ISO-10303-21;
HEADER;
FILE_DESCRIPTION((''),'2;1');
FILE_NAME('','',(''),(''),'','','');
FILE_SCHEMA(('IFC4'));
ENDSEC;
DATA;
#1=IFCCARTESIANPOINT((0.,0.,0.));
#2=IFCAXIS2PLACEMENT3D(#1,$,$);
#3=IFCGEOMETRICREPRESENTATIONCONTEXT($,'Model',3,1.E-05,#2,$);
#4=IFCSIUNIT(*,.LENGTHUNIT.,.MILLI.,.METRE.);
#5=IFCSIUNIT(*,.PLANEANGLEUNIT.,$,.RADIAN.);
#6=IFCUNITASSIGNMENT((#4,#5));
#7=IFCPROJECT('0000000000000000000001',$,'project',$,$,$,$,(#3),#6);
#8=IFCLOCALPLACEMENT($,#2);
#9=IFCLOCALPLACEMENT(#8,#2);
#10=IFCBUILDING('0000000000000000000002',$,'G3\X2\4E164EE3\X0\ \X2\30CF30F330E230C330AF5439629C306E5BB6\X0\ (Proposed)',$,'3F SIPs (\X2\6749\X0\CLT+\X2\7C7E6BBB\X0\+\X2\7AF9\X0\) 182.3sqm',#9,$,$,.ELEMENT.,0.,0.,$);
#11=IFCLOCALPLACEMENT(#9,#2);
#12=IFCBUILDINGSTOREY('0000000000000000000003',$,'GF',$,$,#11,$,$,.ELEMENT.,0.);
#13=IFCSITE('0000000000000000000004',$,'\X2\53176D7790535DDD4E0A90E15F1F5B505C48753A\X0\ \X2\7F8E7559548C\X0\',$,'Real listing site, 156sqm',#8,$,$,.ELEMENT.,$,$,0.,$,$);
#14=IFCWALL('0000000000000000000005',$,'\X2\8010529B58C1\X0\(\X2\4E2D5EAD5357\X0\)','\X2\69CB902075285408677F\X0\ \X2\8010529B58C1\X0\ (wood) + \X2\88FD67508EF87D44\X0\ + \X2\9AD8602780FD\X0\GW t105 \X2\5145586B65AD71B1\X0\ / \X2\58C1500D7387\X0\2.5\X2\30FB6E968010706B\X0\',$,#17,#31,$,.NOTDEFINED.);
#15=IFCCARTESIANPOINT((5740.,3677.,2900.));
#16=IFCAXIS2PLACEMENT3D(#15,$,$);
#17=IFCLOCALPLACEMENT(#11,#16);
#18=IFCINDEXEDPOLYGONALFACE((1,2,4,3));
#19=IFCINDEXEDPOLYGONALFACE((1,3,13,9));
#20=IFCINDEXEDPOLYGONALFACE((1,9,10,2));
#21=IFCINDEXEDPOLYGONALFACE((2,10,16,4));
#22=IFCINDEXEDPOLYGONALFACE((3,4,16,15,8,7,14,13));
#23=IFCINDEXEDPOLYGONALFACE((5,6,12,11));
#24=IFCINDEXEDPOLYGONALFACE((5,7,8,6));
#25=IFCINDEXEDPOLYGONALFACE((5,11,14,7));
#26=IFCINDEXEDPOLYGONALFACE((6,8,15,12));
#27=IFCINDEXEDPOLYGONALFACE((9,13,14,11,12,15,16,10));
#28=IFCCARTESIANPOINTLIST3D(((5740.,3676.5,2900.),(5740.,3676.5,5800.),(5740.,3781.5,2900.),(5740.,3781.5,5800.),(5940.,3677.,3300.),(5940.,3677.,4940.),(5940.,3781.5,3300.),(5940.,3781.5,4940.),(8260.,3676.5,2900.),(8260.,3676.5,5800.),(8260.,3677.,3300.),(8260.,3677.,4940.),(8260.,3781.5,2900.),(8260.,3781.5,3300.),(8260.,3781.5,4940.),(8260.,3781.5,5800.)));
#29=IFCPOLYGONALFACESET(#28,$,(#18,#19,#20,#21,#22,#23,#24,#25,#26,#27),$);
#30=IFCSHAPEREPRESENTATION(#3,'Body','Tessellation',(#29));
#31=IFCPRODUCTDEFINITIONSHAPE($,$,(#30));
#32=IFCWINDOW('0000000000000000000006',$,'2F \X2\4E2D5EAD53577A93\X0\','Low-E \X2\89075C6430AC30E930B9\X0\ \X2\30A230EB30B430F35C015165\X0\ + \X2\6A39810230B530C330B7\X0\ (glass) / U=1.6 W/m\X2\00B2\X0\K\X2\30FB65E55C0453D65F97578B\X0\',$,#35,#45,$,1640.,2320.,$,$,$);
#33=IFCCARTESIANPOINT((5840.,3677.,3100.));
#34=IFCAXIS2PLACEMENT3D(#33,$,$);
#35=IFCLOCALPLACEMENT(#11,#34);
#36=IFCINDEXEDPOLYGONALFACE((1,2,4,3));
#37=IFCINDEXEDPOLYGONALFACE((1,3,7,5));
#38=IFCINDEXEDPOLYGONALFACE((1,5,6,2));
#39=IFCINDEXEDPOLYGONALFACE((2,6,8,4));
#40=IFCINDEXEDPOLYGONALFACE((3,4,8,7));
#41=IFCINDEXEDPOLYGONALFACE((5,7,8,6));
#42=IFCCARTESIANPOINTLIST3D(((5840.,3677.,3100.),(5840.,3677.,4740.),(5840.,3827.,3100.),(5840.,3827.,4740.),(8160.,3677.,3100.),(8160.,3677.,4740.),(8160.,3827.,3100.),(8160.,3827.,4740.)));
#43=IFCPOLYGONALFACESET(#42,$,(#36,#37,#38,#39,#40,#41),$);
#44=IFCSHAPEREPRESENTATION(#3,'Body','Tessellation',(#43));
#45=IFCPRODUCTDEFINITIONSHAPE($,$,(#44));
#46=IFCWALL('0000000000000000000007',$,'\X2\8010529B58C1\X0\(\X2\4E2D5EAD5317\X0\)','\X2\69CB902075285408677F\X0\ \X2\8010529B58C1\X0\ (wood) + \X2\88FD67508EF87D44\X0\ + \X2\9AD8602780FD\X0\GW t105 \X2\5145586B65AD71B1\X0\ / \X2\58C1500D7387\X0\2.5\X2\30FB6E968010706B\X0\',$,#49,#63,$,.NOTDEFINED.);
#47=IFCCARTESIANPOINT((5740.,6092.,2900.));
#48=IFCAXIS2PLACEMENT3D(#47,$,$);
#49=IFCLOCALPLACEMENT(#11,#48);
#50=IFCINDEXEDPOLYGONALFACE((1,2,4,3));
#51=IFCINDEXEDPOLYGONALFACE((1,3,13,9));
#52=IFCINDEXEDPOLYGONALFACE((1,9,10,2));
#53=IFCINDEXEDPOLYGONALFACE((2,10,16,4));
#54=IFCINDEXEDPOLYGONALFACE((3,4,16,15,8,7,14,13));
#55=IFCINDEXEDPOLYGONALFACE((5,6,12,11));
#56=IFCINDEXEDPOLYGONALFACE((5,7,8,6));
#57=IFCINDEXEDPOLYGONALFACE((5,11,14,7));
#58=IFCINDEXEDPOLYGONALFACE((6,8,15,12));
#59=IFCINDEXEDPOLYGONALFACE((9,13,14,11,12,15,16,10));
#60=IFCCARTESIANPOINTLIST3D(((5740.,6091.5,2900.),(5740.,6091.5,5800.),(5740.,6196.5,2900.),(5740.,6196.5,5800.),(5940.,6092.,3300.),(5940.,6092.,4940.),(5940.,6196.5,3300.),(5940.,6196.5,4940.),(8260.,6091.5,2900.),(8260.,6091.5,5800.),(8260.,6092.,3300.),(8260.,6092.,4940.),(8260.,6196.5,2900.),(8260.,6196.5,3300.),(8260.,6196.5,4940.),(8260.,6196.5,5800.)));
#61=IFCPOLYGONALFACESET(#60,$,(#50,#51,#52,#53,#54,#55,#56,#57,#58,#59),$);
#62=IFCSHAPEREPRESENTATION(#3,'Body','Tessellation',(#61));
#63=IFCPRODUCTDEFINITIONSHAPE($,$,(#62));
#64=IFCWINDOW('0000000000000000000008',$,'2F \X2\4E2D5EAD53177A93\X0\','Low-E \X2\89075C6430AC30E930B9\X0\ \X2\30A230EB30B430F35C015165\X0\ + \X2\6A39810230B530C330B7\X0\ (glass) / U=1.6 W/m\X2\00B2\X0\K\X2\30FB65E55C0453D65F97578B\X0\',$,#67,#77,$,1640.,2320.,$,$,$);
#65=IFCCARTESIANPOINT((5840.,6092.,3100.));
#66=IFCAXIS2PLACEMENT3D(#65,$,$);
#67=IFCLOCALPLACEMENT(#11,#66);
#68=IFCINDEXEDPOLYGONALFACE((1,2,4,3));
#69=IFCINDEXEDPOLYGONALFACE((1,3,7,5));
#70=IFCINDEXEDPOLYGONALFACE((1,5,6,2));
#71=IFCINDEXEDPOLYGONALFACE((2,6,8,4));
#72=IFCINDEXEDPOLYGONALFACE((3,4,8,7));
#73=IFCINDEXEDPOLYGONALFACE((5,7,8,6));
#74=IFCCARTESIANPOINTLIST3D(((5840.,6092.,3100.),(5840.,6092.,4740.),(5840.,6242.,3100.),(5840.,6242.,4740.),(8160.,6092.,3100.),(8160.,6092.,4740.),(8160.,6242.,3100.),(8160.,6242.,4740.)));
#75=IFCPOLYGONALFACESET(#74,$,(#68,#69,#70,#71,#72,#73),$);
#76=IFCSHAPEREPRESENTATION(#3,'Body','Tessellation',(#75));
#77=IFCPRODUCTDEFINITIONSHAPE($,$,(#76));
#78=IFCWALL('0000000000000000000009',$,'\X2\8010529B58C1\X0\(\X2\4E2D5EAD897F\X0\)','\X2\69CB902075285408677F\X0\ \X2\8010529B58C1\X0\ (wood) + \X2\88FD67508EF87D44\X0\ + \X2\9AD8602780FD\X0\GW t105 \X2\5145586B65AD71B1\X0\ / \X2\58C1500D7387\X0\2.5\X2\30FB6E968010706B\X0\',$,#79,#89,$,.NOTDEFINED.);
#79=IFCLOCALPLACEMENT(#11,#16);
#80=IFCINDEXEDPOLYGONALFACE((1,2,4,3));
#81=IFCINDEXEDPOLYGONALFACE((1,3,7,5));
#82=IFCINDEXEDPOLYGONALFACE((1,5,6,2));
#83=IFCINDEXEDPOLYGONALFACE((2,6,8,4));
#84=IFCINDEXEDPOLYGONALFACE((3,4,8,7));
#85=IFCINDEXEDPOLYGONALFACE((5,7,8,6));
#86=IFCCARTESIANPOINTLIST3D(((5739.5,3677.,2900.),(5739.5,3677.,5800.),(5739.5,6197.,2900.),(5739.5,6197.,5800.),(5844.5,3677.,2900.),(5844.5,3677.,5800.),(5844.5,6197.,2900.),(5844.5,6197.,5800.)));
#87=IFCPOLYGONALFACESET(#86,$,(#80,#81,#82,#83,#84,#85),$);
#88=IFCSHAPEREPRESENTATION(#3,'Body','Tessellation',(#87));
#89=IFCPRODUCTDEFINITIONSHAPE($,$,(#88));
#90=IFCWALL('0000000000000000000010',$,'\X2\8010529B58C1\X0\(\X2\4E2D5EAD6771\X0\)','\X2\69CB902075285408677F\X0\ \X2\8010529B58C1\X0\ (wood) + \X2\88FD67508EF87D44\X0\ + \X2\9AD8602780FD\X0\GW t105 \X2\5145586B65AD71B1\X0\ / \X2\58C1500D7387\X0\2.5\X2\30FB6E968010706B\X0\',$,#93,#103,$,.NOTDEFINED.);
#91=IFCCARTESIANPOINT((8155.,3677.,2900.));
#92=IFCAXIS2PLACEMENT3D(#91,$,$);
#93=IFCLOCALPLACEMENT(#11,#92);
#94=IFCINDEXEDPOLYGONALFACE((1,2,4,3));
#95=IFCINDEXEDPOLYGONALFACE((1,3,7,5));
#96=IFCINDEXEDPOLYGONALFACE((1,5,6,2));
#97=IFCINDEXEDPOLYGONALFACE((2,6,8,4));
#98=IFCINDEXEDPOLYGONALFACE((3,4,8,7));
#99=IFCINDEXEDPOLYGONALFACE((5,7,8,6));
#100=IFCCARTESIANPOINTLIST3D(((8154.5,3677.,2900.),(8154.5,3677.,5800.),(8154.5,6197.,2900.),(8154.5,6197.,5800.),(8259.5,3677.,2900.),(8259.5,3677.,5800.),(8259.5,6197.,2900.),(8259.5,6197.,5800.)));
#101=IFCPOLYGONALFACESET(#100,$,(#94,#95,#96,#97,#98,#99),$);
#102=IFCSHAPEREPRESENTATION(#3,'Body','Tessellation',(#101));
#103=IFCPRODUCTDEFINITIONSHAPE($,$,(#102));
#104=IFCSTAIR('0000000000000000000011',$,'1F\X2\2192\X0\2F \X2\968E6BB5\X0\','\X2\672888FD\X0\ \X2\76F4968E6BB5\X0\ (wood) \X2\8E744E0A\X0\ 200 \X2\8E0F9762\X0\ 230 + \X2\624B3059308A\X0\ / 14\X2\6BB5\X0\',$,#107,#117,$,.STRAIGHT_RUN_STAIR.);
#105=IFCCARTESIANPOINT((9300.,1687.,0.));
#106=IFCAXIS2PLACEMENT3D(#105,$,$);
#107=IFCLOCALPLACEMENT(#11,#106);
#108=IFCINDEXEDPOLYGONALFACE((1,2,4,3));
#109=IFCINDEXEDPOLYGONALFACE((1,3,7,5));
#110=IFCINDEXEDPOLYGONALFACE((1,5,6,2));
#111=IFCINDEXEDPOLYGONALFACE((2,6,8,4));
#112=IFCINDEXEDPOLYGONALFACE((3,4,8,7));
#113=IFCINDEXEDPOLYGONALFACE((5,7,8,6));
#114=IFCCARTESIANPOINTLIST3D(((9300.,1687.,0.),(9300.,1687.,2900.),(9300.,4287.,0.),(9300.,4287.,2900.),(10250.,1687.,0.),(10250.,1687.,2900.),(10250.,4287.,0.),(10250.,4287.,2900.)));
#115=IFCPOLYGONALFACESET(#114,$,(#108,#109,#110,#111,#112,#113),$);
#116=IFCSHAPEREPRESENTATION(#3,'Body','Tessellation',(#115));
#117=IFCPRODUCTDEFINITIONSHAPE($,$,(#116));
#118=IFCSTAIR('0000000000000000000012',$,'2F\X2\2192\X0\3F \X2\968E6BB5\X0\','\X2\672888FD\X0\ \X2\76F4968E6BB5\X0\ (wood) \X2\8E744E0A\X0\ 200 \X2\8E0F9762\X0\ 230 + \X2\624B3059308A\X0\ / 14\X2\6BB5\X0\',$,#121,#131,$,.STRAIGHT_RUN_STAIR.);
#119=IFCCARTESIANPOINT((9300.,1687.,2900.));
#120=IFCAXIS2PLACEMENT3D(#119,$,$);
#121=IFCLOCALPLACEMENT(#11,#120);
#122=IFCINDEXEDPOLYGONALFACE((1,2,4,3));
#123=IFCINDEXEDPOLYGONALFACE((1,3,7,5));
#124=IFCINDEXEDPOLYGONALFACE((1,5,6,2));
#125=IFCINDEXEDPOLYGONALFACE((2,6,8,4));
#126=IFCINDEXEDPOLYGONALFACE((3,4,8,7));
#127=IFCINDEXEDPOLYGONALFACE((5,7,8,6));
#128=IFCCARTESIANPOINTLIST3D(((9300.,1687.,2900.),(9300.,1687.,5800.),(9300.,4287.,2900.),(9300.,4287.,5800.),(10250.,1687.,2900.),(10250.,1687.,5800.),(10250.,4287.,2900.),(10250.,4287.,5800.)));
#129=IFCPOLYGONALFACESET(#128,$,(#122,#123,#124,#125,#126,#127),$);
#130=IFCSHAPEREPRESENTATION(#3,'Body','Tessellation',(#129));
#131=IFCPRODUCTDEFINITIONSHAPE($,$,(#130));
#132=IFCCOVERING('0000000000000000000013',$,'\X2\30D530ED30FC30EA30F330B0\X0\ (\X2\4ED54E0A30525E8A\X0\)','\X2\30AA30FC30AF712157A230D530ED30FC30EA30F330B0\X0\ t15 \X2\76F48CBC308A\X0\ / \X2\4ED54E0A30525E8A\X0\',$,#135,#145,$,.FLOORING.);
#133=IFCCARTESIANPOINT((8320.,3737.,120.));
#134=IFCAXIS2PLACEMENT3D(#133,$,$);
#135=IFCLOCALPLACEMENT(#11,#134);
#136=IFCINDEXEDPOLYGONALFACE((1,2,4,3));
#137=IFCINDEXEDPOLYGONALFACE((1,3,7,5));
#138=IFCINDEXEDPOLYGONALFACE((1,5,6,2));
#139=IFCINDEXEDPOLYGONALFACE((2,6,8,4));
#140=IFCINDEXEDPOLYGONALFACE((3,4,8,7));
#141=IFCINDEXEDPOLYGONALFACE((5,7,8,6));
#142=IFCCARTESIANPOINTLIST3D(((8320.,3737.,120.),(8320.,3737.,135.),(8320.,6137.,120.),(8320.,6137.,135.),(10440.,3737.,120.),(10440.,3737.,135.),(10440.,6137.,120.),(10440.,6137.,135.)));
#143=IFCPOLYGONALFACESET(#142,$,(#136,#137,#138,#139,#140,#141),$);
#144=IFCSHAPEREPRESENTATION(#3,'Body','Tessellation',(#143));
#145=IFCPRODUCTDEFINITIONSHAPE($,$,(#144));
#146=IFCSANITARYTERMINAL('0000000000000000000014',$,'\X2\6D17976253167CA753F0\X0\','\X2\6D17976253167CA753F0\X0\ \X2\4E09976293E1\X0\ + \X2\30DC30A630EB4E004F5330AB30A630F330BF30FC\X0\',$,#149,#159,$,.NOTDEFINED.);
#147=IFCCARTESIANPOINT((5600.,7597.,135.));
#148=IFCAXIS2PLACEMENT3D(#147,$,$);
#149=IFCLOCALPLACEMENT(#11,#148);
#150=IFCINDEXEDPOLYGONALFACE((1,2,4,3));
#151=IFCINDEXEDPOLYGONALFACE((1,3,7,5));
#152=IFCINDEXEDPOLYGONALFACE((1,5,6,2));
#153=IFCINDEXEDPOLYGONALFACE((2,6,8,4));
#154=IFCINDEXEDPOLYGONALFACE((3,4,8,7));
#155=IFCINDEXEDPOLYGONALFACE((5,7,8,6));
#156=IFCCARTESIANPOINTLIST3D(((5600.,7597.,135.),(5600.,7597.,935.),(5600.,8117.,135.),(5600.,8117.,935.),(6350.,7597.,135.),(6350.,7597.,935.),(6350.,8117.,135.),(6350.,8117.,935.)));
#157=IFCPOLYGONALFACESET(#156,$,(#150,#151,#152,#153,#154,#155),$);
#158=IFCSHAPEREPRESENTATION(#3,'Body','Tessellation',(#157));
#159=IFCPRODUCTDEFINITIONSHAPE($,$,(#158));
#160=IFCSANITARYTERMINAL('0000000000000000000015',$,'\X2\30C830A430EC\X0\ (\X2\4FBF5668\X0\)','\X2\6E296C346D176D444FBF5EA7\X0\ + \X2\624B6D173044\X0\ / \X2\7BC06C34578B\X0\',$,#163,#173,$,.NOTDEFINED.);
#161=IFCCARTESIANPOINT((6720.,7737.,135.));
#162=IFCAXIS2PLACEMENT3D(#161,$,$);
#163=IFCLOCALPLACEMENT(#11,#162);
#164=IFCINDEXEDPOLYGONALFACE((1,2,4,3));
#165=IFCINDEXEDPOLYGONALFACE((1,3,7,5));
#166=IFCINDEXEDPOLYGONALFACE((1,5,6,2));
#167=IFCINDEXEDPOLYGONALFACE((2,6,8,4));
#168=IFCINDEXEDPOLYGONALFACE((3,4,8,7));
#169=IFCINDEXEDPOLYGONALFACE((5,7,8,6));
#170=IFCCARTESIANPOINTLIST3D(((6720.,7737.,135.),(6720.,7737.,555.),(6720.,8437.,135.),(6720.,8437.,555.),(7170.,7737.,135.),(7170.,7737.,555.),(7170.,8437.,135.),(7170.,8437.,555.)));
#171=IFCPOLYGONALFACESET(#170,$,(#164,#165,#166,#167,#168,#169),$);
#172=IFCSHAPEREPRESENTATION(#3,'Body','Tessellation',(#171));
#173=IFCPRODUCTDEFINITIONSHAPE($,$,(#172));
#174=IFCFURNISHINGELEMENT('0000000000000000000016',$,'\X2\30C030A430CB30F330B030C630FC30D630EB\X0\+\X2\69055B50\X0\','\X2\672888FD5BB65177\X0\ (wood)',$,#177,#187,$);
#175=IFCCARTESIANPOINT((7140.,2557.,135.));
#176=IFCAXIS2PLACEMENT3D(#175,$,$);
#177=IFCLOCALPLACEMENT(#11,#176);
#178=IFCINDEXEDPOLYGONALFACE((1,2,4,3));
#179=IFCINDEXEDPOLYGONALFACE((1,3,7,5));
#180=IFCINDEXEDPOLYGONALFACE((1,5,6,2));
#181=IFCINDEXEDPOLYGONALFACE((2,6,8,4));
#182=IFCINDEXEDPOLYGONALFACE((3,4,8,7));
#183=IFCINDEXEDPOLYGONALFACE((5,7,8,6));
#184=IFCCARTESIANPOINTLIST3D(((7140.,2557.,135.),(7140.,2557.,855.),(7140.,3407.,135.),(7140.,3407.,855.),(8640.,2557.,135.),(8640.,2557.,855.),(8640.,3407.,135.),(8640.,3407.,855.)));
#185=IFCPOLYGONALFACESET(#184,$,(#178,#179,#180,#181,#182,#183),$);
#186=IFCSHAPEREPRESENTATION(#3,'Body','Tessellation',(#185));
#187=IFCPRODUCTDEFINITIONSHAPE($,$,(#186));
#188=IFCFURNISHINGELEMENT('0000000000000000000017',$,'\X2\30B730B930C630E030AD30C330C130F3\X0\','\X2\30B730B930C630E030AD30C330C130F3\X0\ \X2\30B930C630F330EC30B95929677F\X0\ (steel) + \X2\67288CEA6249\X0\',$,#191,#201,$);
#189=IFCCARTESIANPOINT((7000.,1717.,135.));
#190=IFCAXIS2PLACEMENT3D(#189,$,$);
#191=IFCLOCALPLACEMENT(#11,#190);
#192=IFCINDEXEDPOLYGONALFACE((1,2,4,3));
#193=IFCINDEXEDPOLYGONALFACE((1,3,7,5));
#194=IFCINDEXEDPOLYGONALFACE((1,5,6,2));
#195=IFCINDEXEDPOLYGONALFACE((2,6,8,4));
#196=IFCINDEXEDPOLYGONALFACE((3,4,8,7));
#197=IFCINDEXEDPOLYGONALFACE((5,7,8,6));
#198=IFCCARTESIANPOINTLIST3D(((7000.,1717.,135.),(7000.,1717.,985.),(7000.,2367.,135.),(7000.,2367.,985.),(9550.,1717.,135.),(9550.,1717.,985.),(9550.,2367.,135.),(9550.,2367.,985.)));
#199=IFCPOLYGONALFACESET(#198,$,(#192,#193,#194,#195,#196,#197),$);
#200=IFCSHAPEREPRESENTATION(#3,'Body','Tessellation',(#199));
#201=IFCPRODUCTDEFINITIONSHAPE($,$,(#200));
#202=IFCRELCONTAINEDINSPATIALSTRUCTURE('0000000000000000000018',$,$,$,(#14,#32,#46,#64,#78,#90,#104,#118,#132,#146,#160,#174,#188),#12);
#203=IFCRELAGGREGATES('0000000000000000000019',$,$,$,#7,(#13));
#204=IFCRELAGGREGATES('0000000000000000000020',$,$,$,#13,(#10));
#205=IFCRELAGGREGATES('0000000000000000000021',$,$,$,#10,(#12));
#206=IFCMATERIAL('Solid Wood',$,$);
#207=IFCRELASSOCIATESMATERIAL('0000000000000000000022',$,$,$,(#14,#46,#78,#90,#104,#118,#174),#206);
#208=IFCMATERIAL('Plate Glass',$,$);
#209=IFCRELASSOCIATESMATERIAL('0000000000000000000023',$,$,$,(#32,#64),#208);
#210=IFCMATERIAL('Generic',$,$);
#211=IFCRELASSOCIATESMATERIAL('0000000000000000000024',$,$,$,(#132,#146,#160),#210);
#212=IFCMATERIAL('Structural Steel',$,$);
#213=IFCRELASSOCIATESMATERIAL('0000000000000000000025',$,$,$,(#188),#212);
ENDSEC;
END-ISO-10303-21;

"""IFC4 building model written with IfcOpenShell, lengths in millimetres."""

from ifc_helpers import new_model, si_unit, frame, frame_2d, origin, place, context, project, spatial, rectangle, extrude, material, element, fill, save


model = new_model("IFC4")

# Units and contexts
model_context = context("Model", 3, precision=1e-05, world=origin())
ifc_project = project(units=[si_unit("LENGTHUNIT", "METRE", prefix="MILLI"), si_unit("PLANEANGLEUNIT", "RADIAN")], contexts=[model_context])

# Site, building, storey
site_placement = place(None, origin())
site = spatial("IfcSite", under=ifc_project, at=site_placement, Name="北海道川上郡弟子屈町 美留和", ObjectType="Real listing site, 156sqm", CompositionType="ELEMENT", RefElevation=0.0)
building_placement = place(site_placement, origin())
building = spatial("IfcBuilding", under=site, at=building_placement, Name="G3世代 ハンモック吹抜の家 (Proposed)", ObjectType="3F SIPs (杉CLT+籾殻+竹) 182.3sqm", CompositionType="ELEMENT", ElevationOfRefHeight=0.0, ElevationOfTerrain=0.0)
storey_placement = place(building_placement, origin())
storey = spatial("IfcBuildingStorey", under=building, at=storey_placement, Name="GF", CompositionType="ELEMENT", Elevation=0.0)

# Shared definitions
ifc_material_1 = material(Name="Solid Wood")

# Shared definitions
ifc_material_2 = material(Name="Plate Glass")

# Walls, openings, windows
wall_1_placement = place(storey_placement, frame((5740.0, 3677.0, 2900.0)))
wall_1 = element("IfcWall", 1, at=wall_1_placement, inside=storey, material=ifc_material_1, Name="耐力壁(中庭南)", Description="構造用合板 耐力壁 (wood) + 製材軸組 + 高性能GW t105 充填断熱 / 壁倍率2.5・準耐火", PredefinedType="NOTDEFINED", context=model_context, shape_type="SweptSolid", body=[
    extrude(rectangle(XDim=2520.0, YDim=105.0, at=frame_2d((1260.0, 52.0))), frame((5740.0, 3677.0, 2900.0)), (0.0, 0.0, 1.0), 2900.0),
])
opening_1_placement = place(storey_placement, frame((5840.0, 3677.0, 3100.0)))
opening_1 = element("IfcOpeningElement", 2, at=opening_1_placement, cuts=wall_1, PredefinedType="NOTDEFINED", context=model_context, shape_type="SweptSolid", body=[
    extrude(rectangle(XDim=2320.0, YDim=150.0, at=frame_2d((1160.0, 75.0))), frame((5840.0, 3677.0, 3100.0)), (0.0, 0.0, 1.0), 1640.0),
])
window_1_placement = place(storey_placement, frame((5840.0, 3677.0, 3100.0)))
window_1 = element("IfcWindow", 3, at=window_1_placement, inside=storey, material=ifc_material_2, Name="2F 中庭南窓", Description="Low-E 複層ガラス アルゴン封入 + 樹脂サッシ (glass) / U=1.6 W/m²K・日射取得型", OverallHeight=1640.0, OverallWidth=2320.0, context=model_context, shape_type="SweptSolid", body=[
    extrude(rectangle(XDim=2320.0, YDim=150.0, at=frame_2d((1160.0, 75.0))), frame((5840.0, 3677.0, 3100.0)), (0.0, 0.0, 1.0), 1640.0),
])
fill(opening_1, window_1)
wall_2_placement = place(storey_placement, frame((5740.0, 6092.0, 2900.0)))
wall_2 = element("IfcWall", 4, at=wall_2_placement, inside=storey, material=ifc_material_1, Name="耐力壁(中庭北)", Description="構造用合板 耐力壁 (wood) + 製材軸組 + 高性能GW t105 充填断熱 / 壁倍率2.5・準耐火", PredefinedType="NOTDEFINED", context=model_context, shape_type="SweptSolid", body=[
    extrude(rectangle(XDim=2520.0, YDim=105.0, at=frame_2d((1260.0, 52.0))), frame((5740.0, 6092.0, 2900.0)), (0.0, 0.0, 1.0), 2900.0),
])
opening_2_placement = place(storey_placement, frame((5840.0, 6092.0, 3100.0)))
opening_2 = element("IfcOpeningElement", 5, at=opening_2_placement, cuts=wall_2, PredefinedType="NOTDEFINED", context=model_context, shape_type="SweptSolid", body=[
    extrude(rectangle(XDim=2320.0, YDim=150.0, at=frame_2d((1160.0, 75.0))), frame((5840.0, 6092.0, 3100.0)), (0.0, 0.0, 1.0), 1640.0),
])
window_2_placement = place(storey_placement, frame((5840.0, 6092.0, 3100.0)))
window_2 = element("IfcWindow", 6, at=window_2_placement, inside=storey, material=ifc_material_2, Name="2F 中庭北窓", Description="Low-E 複層ガラス アルゴン封入 + 樹脂サッシ (glass) / U=1.6 W/m²K・日射取得型", OverallHeight=1640.0, OverallWidth=2320.0, context=model_context, shape_type="SweptSolid", body=[
    extrude(rectangle(XDim=2320.0, YDim=150.0, at=frame_2d((1160.0, 75.0))), frame((5840.0, 6092.0, 3100.0)), (0.0, 0.0, 1.0), 1640.0),
])
fill(opening_2, window_2)

# Walls
wall_3_placement = place(storey_placement, frame((5740.0, 3677.0, 2900.0)))
element("IfcWall", 7, at=wall_3_placement, inside=storey, material=ifc_material_1, Name="耐力壁(中庭西)", Description="構造用合板 耐力壁 (wood) + 製材軸組 + 高性能GW t105 充填断熱 / 壁倍率2.5・準耐火", PredefinedType="NOTDEFINED", context=model_context, shape_type="SweptSolid", body=[
    extrude(rectangle(XDim=105.0, YDim=2520.0, at=frame_2d((52.0, 1260.0))), frame((5740.0, 3677.0, 2900.0)), (0.0, 0.0, 1.0), 2900.0),
])
wall_4_placement = place(storey_placement, frame((8155.0, 3677.0, 2900.0)))
element("IfcWall", 8, at=wall_4_placement, inside=storey, material=ifc_material_1, Name="耐力壁(中庭東)", Description="構造用合板 耐力壁 (wood) + 製材軸組 + 高性能GW t105 充填断熱 / 壁倍率2.5・準耐火", PredefinedType="NOTDEFINED", context=model_context, shape_type="SweptSolid", body=[
    extrude(rectangle(XDim=105.0, YDim=2520.0, at=frame_2d((52.0, 1260.0))), frame((8155.0, 3677.0, 2900.0)), (0.0, 0.0, 1.0), 2900.0),
])

# Stairs
stair_1_placement = place(storey_placement, frame((9300.0, 1687.0, 0.0)))
element("IfcStair", 9, at=stair_1_placement, inside=storey, material=ifc_material_1, Name="1F→2F 階段", Description="木製 直階段 (wood) 蹴上 200 踏面 230 + 手すり / 14段", PredefinedType="STRAIGHT_RUN_STAIR", context=model_context, shape_type="SweptSolid", body=[
    extrude(rectangle(XDim=950.0, YDim=2600.0, at=frame_2d((475.0, 1300.0))), frame((9300.0, 1687.0, 0.0)), (0.0, 0.0, 1.0), 2900.0),
])
stair_2_placement = place(storey_placement, frame((9300.0, 1687.0, 2900.0)))
element("IfcStair", 10, at=stair_2_placement, inside=storey, material=ifc_material_1, Name="2F→3F 階段", Description="木製 直階段 (wood) 蹴上 200 踏面 230 + 手すり / 14段", PredefinedType="STRAIGHT_RUN_STAIR", context=model_context, shape_type="SweptSolid", body=[
    extrude(rectangle(XDim=950.0, YDim=2600.0, at=frame_2d((475.0, 1300.0))), frame((9300.0, 1687.0, 2900.0)), (0.0, 0.0, 1.0), 2900.0),
])

# Covering
ifc_material_3 = material(Name="Generic")
covering_placement = place(storey_placement, frame((8320.0, 3737.0, 120.0)))
element("IfcCovering", 11, at=covering_placement, inside=storey, material=ifc_material_3, Name="フローリング (仕上げ床)", Description="オーク無垢フローリング t15 直貼り / 仕上げ床", PredefinedType="FLOORING", context=model_context, shape_type="SweptSolid", body=[
    extrude(rectangle(XDim=2120.0, YDim=2400.0, at=frame_2d((1060.0, 1200.0))), frame((8320.0, 3737.0, 120.0)), (0.0, 0.0, 1.0), 15.0),
])

# Sanitary terminals
sanitary_terminal_1_placement = place(storey_placement, frame((5600.0, 7597.0, 135.0)))
element("IfcSanitaryTerminal", 12, at=sanitary_terminal_1_placement, inside=storey, material=ifc_material_3, Name="洗面化粧台", Description="洗面化粧台 三面鏡 + ボウル一体カウンター", PredefinedType="NOTDEFINED", context=model_context, shape_type="SweptSolid", body=[
    extrude(rectangle(XDim=750.0, YDim=520.0, at=frame_2d((375.0, 260.0))), frame((5600.0, 7597.0, 135.0)), (0.0, 0.0, 1.0), 800.0),
])
sanitary_terminal_2_placement = place(storey_placement, frame((6720.0, 7737.0, 135.0)))
element("IfcSanitaryTerminal", 13, at=sanitary_terminal_2_placement, inside=storey, material=ifc_material_3, Name="トイレ (便器)", Description="温水洗浄便座 + 手洗い / 節水型", PredefinedType="NOTDEFINED", context=model_context, shape_type="SweptSolid", body=[
    extrude(rectangle(XDim=450.0, YDim=700.0, at=frame_2d((225.0, 350.0))), frame((6720.0, 7737.0, 135.0)), (0.0, 0.0, 1.0), 420.0),
])

# Furnishing elements
furnishing_1_placement = place(storey_placement, frame((7140.0, 2557.0, 135.0)))
element("IfcFurnishingElement", 14, at=furnishing_1_placement, inside=storey, material=ifc_material_1, Name="ダイニングテーブル+椅子", Description="木製家具 (wood)", context=model_context, shape_type="SweptSolid", body=[
    extrude(rectangle(XDim=1500.0, YDim=850.0, at=frame_2d((750.0, 425.0))), frame((7140.0, 2557.0, 135.0)), (0.0, 0.0, 1.0), 720.0),
])
ifc_material_4 = material(Name="Structural Steel")
furnishing_2_placement = place(storey_placement, frame((7000.0, 1717.0, 135.0)))
element("IfcFurnishingElement", 15, at=furnishing_2_placement, inside=storey, material=ifc_material_4, Name="システムキッチン", Description="システムキッチン ステンレス天板 (steel) + 木質扉", context=model_context, shape_type="SweptSolid", body=[
    extrude(rectangle(XDim=2550.0, YDim=650.0, at=frame_2d((1275.0, 325.0))), frame((7000.0, 1717.0, 135.0)), (0.0, 0.0, 1.0), 850.0),
])

save(model, "model.ifc")
